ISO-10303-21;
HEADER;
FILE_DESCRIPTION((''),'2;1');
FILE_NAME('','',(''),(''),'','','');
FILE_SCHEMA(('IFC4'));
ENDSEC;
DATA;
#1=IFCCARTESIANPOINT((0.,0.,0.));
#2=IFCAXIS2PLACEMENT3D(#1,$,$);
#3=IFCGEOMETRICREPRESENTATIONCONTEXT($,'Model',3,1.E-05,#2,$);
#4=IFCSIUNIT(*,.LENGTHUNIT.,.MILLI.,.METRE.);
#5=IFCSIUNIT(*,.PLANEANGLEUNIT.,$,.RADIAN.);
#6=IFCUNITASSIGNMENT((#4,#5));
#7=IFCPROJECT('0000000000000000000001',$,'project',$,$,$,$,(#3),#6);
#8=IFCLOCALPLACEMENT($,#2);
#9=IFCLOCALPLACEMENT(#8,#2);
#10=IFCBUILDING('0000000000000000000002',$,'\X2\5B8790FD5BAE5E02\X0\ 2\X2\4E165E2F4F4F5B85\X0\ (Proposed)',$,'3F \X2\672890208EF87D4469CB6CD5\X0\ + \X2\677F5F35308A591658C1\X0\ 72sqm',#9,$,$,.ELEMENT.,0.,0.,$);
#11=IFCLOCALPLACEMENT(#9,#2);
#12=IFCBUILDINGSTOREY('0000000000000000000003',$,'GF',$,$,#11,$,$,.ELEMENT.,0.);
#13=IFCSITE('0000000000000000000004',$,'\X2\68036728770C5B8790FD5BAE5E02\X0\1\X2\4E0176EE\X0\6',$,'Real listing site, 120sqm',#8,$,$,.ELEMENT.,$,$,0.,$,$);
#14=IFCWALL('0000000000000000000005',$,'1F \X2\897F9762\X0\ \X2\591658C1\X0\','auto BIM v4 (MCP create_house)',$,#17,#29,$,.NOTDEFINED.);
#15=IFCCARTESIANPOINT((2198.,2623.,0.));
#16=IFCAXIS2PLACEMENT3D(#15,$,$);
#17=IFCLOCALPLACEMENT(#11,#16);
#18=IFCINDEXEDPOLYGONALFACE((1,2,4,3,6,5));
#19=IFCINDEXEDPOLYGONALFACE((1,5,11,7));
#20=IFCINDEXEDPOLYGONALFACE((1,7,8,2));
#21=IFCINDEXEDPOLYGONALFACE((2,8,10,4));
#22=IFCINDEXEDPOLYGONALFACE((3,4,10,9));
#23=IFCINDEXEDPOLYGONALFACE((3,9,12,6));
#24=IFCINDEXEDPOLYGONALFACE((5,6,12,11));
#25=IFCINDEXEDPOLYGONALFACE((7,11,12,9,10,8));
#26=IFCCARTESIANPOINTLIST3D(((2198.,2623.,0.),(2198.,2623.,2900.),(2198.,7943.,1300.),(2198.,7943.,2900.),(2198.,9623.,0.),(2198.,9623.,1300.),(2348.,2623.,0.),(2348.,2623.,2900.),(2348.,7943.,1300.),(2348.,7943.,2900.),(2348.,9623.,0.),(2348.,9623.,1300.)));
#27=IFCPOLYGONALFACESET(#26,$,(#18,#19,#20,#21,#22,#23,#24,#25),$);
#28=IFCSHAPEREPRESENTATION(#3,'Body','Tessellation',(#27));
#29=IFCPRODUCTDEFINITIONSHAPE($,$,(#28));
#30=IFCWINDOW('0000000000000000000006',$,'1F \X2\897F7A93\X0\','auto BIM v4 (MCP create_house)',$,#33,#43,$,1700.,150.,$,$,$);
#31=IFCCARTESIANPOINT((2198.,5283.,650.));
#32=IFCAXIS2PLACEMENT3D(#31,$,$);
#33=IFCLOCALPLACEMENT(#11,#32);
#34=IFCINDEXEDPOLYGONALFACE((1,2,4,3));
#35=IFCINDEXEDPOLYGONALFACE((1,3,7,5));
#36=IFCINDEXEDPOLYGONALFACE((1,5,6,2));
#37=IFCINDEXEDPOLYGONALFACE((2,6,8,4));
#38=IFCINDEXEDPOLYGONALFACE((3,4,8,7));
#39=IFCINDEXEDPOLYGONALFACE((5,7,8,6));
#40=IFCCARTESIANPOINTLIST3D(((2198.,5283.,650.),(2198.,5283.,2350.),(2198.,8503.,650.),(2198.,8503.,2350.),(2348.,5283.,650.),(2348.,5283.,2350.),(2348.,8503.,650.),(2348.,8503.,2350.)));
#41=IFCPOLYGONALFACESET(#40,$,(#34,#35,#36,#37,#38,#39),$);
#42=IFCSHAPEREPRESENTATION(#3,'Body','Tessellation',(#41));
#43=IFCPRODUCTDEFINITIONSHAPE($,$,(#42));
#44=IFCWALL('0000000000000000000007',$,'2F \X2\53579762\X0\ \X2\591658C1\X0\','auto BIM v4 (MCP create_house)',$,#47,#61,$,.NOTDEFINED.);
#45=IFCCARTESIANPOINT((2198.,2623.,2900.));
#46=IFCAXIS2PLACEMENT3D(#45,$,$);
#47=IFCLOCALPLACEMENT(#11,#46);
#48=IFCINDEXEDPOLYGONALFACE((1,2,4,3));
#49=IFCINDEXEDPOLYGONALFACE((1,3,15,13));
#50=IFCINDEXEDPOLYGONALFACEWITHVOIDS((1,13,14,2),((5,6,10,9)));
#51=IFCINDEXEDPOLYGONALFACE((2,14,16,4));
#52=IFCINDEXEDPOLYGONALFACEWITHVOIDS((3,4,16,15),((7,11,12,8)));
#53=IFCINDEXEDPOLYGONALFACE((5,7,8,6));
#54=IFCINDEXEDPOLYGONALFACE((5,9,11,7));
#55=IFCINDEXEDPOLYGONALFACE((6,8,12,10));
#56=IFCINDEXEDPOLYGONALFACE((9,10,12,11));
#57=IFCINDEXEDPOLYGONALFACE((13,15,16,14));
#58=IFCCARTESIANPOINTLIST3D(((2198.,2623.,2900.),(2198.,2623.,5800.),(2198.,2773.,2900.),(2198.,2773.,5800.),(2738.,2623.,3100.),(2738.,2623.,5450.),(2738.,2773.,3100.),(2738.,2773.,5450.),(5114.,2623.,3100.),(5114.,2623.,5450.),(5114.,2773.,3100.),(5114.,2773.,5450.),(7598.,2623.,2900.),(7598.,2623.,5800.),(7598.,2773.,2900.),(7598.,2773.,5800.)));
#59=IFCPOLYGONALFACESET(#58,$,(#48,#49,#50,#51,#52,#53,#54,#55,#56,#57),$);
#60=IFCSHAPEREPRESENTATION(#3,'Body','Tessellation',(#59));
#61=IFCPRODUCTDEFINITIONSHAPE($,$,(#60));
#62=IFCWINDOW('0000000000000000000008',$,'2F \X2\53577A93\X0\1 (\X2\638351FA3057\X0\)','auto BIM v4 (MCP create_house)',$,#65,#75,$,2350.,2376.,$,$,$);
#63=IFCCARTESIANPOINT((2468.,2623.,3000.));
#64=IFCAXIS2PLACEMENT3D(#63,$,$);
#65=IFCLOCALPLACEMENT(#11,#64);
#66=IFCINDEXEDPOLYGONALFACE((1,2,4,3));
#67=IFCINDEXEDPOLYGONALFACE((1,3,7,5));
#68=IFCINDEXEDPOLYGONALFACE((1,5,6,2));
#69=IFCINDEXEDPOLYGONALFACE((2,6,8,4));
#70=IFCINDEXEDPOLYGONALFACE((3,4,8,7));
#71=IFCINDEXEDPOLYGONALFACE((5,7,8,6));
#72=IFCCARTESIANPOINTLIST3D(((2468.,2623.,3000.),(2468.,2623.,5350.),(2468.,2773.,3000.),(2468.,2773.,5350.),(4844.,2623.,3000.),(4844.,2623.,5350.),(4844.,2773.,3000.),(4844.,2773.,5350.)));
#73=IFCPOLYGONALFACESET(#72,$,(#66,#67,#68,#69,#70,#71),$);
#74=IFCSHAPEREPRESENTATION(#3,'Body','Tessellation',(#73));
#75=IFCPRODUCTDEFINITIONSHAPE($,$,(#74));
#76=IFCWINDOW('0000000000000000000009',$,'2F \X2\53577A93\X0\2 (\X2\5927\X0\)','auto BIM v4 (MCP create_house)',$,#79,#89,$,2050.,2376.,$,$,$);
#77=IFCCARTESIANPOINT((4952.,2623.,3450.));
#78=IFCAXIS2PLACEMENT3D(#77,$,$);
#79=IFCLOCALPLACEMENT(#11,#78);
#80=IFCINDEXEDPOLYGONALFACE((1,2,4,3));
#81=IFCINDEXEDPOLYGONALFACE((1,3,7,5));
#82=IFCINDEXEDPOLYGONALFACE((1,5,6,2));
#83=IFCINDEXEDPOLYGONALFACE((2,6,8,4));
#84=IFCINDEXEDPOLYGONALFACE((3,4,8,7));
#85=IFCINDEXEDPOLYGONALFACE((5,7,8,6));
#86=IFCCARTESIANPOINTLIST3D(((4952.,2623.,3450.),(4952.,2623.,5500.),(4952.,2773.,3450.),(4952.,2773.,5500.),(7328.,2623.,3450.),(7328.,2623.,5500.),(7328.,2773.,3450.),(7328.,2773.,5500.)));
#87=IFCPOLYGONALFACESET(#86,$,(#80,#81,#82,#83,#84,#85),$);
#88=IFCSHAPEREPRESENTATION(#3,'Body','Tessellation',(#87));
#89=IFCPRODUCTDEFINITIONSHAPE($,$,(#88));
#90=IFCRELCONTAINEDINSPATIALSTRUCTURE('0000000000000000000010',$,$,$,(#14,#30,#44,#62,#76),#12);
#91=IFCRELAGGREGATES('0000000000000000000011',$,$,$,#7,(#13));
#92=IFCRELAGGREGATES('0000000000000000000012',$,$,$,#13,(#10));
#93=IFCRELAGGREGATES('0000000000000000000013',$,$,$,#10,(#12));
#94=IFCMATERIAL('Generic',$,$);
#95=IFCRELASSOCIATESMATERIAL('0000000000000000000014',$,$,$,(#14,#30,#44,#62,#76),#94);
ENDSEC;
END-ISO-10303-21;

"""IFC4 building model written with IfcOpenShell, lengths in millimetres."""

from ifc_helpers import new_model, si_unit, frame, frame_2d, origin, place, context, project, spatial, rectangle, extrude, material, element, fill, save


model = new_model("IFC4")

# Units and contexts
model_context = context("Model", 3, precision=1e-05, world=origin())
ifc_project = project(units=[si_unit("LENGTHUNIT", "METRE", prefix="MILLI"), si_unit("PLANEANGLEUNIT", "RADIAN")], contexts=[model_context])

# Site, building, storey
site_placement = place(None, origin())
site = spatial("IfcSite", under=ifc_project, at=site_placement, Name="栃木県宇都宮市1丁目6", ObjectType="Real listing site, 120sqm", CompositionType="ELEMENT", RefElevation=0.0)
building_placement = place(site_placement, origin())
building = spatial("IfcBuilding", under=site, at=building_placement, Name="宇都宮市 2世帯住宅 (Proposed)", ObjectType="3F 木造軸組構法 + 板張り外壁 72sqm", CompositionType="ELEMENT", ElevationOfRefHeight=0.0, ElevationOfTerrain=0.0)
storey_placement = place(building_placement, origin())
storey = spatial("IfcBuildingStorey", under=building, at=storey_placement, Name="GF", CompositionType="ELEMENT", Elevation=0.0)

# Shared definitions
ifc_material = material(Name="Generic")

# Wall, opening, window
wall_1_placement = place(storey_placement, frame((2198.0, 2623.0, 0.0)))
wall_1 = element("IfcWall", 1, at=wall_1_placement, inside=storey, material=ifc_material, Name="1F 西面 外壁", Description="auto BIM v4 (MCP create_house)", PredefinedType="NOTDEFINED", context=model_context, shape_type="SweptSolid", body=[
    extrude(rectangle(XDim=150.0, YDim=7000.0, at=frame_2d((75.0, 3500.0))), frame((2198.0, 2623.0, 0.0)), (0.0, 0.0, 1.0), 2900.0),
])
opening_1_placement = place(storey_placement, frame((2198.0, 5283.0, 650.0)))
opening_1 = element("IfcOpeningElement", 2, at=opening_1_placement, cuts=wall_1, PredefinedType="NOTDEFINED", context=model_context, shape_type="SweptSolid", body=[
    extrude(rectangle(XDim=150.0, YDim=3220.0, at=frame_2d((75.0, 1610.0))), frame((2198.0, 5283.0, 650.0)), (0.0, 0.0, 1.0), 1700.0),
])
window_1_placement = place(storey_placement, frame((2198.0, 5283.0, 650.0)))
window_1 = element("IfcWindow", 3, at=window_1_placement, inside=storey, material=ifc_material, Name="1F 西窓", Description="auto BIM v4 (MCP create_house)", OverallHeight=1700.0, OverallWidth=150.0, context=model_context, shape_type="SweptSolid", body=[
    extrude(rectangle(XDim=150.0, YDim=3220.0, at=frame_2d((75.0, 1610.0))), frame((2198.0, 5283.0, 650.0)), (0.0, 0.0, 1.0), 1700.0),
])
fill(opening_1, window_1)

# Wall, openings, windows
wall_2_placement = place(storey_placement, frame((2198.0, 2623.0, 2900.0)))
wall_2 = element("IfcWall", 4, at=wall_2_placement, inside=storey, material=ifc_material, Name="2F 南面 外壁", Description="auto BIM v4 (MCP create_house)", PredefinedType="NOTDEFINED", context=model_context, shape_type="SweptSolid", body=[
    extrude(rectangle(XDim=5400.0, YDim=150.0, at=frame_2d((2700.0, 75.0))), frame((2198.0, 2623.0, 2900.0)), (0.0, 0.0, 1.0), 2900.0),
])
opening_2_placement = place(storey_placement, frame((2468.0, 2623.0, 3000.0)))
opening_2 = element("IfcOpeningElement", 5, at=opening_2_placement, cuts=wall_2, PredefinedType="NOTDEFINED", context=model_context, shape_type="SweptSolid", body=[
    extrude(rectangle(XDim=2376.0, YDim=150.0, at=frame_2d((1188.0, 75.0))), frame((2468.0, 2623.0, 3000.0)), (0.0, 0.0, 1.0), 2350.0),
])
opening_3_placement = place(storey_placement, frame((4952.0, 2623.0, 3450.0)))
opening_3 = element("IfcOpeningElement", 6, at=opening_3_placement, cuts=wall_2, PredefinedType="NOTDEFINED", context=model_context, shape_type="SweptSolid", body=[
    extrude(rectangle(XDim=2376.0, YDim=150.0, at=frame_2d((1188.0, 75.0))), frame((4952.0, 2623.0, 3450.0)), (0.0, 0.0, 1.0), 2050.0),
])
window_2_placement = place(storey_placement, frame((2468.0, 2623.0, 3000.0)))
window_2 = element("IfcWindow", 7, at=window_2_placement, inside=storey, material=ifc_material, Name="2F 南窓1 (掃出し)", Description="auto BIM v4 (MCP create_house)", OverallHeight=2350.0, OverallWidth=2376.0, context=model_context, shape_type="SweptSolid", body=[
    extrude(rectangle(XDim=2376.0, YDim=150.0, at=frame_2d((1188.0, 75.0))), frame((2468.0, 2623.0, 3000.0)), (0.0, 0.0, 1.0), 2350.0),
])
fill(opening_2, window_2)
window_3_placement = place(storey_placement, frame((4952.0, 2623.0, 3450.0)))
window_3 = element("IfcWindow", 8, at=window_3_placement, inside=storey, material=ifc_material, Name="2F 南窓2 (大)", Description="auto BIM v4 (MCP create_house)", OverallHeight=2050.0, OverallWidth=2376.0, context=model_context, shape_type="SweptSolid", body=[
    extrude(rectangle(XDim=2376.0, YDim=150.0, at=frame_2d((1188.0, 75.0))), frame((4952.0, 2623.0, 3450.0)), (0.0, 0.0, 1.0), 2050.0),
])
fill(opening_3, window_3)

save(model, "model.ifc")
